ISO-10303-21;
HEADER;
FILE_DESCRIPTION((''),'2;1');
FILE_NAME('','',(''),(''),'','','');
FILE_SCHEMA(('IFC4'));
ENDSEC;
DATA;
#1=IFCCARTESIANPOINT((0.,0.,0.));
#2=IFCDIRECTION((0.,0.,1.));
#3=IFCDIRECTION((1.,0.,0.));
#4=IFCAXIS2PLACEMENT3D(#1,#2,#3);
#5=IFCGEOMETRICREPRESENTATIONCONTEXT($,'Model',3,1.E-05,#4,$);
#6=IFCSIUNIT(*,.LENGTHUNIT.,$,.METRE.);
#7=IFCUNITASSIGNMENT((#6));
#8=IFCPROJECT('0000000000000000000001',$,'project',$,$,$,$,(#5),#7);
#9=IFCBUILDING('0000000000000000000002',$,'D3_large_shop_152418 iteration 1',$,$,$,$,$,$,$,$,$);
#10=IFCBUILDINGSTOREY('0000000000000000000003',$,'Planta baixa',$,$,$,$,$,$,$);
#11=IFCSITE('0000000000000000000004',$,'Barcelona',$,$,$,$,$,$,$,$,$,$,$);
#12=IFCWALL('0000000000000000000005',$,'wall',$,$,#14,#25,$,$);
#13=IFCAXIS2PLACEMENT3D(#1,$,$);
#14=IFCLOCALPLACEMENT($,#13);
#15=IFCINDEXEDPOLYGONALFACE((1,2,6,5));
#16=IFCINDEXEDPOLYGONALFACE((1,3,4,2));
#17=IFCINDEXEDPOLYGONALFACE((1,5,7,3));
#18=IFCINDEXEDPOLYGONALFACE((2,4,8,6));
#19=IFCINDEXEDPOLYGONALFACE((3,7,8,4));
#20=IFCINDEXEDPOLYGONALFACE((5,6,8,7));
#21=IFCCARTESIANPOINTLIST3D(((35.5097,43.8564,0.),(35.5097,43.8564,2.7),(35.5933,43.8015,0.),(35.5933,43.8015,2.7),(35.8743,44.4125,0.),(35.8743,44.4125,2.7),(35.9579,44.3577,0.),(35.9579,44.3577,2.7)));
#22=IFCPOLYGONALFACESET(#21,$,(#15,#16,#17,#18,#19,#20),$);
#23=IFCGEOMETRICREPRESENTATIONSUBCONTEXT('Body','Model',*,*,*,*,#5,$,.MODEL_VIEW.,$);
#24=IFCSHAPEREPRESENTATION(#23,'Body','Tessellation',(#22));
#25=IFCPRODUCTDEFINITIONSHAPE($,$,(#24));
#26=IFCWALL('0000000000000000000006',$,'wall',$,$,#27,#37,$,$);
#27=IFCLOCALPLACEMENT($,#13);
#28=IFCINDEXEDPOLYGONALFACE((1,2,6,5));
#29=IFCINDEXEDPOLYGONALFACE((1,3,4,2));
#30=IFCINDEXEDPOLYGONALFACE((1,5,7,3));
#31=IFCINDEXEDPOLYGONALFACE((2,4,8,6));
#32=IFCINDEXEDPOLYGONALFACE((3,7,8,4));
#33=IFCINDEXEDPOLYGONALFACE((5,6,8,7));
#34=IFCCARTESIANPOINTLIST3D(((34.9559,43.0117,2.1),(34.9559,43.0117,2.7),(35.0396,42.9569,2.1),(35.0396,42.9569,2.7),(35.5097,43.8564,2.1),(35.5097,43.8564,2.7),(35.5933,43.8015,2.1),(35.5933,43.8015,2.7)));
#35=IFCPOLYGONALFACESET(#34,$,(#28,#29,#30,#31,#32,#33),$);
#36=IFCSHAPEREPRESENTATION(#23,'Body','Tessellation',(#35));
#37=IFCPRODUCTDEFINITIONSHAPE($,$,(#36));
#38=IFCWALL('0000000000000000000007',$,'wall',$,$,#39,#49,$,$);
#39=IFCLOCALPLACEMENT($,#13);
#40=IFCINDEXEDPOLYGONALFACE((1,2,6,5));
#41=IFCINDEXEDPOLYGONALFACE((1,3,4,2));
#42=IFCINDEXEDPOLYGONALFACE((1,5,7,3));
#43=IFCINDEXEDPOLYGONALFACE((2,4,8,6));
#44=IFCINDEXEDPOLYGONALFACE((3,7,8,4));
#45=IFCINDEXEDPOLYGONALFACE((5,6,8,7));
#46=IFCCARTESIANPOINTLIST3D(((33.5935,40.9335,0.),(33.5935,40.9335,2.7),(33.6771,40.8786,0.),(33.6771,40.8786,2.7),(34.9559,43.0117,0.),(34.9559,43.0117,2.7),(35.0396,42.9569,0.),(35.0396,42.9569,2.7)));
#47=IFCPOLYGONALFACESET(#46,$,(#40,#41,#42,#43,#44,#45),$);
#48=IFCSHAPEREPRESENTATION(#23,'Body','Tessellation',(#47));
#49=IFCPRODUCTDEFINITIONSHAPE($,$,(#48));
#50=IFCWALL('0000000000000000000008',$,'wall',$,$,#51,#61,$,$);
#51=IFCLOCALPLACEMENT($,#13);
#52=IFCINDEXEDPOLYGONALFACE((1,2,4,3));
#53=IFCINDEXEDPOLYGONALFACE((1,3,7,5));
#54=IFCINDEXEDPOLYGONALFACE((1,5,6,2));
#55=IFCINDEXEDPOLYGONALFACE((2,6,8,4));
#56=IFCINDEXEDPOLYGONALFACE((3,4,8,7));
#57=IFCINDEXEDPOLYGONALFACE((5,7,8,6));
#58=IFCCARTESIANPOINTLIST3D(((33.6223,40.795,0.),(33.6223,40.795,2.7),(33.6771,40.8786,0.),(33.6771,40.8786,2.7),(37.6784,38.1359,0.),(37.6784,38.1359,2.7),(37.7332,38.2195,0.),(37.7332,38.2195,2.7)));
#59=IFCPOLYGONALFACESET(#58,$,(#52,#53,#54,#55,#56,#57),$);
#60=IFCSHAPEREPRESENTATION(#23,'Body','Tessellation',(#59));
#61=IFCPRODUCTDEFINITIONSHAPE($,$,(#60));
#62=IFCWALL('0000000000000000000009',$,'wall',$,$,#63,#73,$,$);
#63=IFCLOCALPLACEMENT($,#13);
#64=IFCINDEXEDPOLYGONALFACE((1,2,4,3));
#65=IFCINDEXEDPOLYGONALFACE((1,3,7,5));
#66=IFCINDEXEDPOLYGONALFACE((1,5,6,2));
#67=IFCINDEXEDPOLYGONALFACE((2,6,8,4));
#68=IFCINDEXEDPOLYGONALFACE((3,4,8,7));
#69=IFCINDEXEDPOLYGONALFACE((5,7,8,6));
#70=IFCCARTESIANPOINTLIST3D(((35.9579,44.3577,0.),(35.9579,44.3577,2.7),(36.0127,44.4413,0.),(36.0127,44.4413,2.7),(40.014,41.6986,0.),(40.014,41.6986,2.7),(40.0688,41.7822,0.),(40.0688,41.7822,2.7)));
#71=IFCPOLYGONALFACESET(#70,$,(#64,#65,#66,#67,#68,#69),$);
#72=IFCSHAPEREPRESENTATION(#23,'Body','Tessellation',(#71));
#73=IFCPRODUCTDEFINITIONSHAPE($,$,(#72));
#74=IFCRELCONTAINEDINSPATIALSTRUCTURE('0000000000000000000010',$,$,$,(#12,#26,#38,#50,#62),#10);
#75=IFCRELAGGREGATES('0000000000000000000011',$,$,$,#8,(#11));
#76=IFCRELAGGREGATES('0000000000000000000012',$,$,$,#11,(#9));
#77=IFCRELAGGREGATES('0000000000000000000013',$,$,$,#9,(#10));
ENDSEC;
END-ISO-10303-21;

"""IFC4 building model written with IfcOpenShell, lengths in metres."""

from ifc_helpers import new_model, si_unit, frame, origin, origin_with_axes, place, context, subcontext, project, spatial, polyline, outline, extrude, element, save


model = new_model("IFC4")

# Units and contexts
model_context = context("Model", 3, precision=1e-05, world=origin_with_axes())
body_context = subcontext(model_context, "Body", "Model", "MODEL_VIEW")
ifc_project = project(units=[si_unit("LENGTHUNIT", "METRE")], contexts=[model_context])

# Site, building, storey
site = spatial("IfcSite", under=ifc_project, Name="Barcelona")
building = spatial("IfcBuilding", under=site, Name="D3_large_shop_152418 iteration 1")
storey = spatial("IfcBuildingStorey", under=building, Name="Planta baixa")

# Walls
wall_1_placement = place(None, origin_with_axes())
element("IfcWall", 1, at=wall_1_placement, inside=storey, Name="wall", context=body_context, shape_type="SweptSolid", body=[
    extrude(outline(polyline([(35.9579, 44.3577), (35.5933, 43.8015), (35.5097, 43.8564), (35.8743, 44.4125), (35.9579, 44.3577)])), origin(), (0.0, 0.0, 1.0), 2.7),
])
wall_2_placement = place(None, origin_with_axes())
element("IfcWall", 2, at=wall_2_placement, inside=storey, Name="wall", context=body_context, shape_type="SweptSolid", body=[
    extrude(outline(polyline([(35.5933, 43.8015), (35.0396, 42.9569), (34.9559, 43.0117), (35.5097, 43.8564), (35.5933, 43.8015)])), frame((0.0, 0.0, 2.1)), (0.0, 0.0, 1.0), 0.6),
])
wall_3_placement = place(None, origin_with_axes())
element("IfcWall", 3, at=wall_3_placement, inside=storey, Name="wall", context=body_context, shape_type="SweptSolid", body=[
    extrude(outline(polyline([(35.0396, 42.9569), (33.6771, 40.8786), (33.5935, 40.9335), (34.9559, 43.0117), (35.0396, 42.9569)])), origin(), (0.0, 0.0, 1.0), 2.7),
])
wall_4_placement = place(None, origin_with_axes())
element("IfcWall", 4, at=wall_4_placement, inside=storey, Name="wall", context=body_context, shape_type="SweptSolid", body=[
    extrude(outline(polyline([(33.6771, 40.8786), (37.7332, 38.2195), (37.6784, 38.1359), (33.6223, 40.795), (33.6771, 40.8786)])), origin(), (0.0, 0.0, 1.0), 2.7),
])
wall_5_placement = place(None, origin_with_axes())
element("IfcWall", 5, at=wall_5_placement, inside=storey, Name="wall", context=body_context, shape_type="SweptSolid", body=[
    extrude(outline(polyline([(40.014, 41.6986), (35.9579, 44.3577), (36.0127, 44.4413), (40.0688, 41.7822), (40.014, 41.6986)])), origin(), (0.0, 0.0, 1.0), 2.7),
])

save(model, "model.ifc")
